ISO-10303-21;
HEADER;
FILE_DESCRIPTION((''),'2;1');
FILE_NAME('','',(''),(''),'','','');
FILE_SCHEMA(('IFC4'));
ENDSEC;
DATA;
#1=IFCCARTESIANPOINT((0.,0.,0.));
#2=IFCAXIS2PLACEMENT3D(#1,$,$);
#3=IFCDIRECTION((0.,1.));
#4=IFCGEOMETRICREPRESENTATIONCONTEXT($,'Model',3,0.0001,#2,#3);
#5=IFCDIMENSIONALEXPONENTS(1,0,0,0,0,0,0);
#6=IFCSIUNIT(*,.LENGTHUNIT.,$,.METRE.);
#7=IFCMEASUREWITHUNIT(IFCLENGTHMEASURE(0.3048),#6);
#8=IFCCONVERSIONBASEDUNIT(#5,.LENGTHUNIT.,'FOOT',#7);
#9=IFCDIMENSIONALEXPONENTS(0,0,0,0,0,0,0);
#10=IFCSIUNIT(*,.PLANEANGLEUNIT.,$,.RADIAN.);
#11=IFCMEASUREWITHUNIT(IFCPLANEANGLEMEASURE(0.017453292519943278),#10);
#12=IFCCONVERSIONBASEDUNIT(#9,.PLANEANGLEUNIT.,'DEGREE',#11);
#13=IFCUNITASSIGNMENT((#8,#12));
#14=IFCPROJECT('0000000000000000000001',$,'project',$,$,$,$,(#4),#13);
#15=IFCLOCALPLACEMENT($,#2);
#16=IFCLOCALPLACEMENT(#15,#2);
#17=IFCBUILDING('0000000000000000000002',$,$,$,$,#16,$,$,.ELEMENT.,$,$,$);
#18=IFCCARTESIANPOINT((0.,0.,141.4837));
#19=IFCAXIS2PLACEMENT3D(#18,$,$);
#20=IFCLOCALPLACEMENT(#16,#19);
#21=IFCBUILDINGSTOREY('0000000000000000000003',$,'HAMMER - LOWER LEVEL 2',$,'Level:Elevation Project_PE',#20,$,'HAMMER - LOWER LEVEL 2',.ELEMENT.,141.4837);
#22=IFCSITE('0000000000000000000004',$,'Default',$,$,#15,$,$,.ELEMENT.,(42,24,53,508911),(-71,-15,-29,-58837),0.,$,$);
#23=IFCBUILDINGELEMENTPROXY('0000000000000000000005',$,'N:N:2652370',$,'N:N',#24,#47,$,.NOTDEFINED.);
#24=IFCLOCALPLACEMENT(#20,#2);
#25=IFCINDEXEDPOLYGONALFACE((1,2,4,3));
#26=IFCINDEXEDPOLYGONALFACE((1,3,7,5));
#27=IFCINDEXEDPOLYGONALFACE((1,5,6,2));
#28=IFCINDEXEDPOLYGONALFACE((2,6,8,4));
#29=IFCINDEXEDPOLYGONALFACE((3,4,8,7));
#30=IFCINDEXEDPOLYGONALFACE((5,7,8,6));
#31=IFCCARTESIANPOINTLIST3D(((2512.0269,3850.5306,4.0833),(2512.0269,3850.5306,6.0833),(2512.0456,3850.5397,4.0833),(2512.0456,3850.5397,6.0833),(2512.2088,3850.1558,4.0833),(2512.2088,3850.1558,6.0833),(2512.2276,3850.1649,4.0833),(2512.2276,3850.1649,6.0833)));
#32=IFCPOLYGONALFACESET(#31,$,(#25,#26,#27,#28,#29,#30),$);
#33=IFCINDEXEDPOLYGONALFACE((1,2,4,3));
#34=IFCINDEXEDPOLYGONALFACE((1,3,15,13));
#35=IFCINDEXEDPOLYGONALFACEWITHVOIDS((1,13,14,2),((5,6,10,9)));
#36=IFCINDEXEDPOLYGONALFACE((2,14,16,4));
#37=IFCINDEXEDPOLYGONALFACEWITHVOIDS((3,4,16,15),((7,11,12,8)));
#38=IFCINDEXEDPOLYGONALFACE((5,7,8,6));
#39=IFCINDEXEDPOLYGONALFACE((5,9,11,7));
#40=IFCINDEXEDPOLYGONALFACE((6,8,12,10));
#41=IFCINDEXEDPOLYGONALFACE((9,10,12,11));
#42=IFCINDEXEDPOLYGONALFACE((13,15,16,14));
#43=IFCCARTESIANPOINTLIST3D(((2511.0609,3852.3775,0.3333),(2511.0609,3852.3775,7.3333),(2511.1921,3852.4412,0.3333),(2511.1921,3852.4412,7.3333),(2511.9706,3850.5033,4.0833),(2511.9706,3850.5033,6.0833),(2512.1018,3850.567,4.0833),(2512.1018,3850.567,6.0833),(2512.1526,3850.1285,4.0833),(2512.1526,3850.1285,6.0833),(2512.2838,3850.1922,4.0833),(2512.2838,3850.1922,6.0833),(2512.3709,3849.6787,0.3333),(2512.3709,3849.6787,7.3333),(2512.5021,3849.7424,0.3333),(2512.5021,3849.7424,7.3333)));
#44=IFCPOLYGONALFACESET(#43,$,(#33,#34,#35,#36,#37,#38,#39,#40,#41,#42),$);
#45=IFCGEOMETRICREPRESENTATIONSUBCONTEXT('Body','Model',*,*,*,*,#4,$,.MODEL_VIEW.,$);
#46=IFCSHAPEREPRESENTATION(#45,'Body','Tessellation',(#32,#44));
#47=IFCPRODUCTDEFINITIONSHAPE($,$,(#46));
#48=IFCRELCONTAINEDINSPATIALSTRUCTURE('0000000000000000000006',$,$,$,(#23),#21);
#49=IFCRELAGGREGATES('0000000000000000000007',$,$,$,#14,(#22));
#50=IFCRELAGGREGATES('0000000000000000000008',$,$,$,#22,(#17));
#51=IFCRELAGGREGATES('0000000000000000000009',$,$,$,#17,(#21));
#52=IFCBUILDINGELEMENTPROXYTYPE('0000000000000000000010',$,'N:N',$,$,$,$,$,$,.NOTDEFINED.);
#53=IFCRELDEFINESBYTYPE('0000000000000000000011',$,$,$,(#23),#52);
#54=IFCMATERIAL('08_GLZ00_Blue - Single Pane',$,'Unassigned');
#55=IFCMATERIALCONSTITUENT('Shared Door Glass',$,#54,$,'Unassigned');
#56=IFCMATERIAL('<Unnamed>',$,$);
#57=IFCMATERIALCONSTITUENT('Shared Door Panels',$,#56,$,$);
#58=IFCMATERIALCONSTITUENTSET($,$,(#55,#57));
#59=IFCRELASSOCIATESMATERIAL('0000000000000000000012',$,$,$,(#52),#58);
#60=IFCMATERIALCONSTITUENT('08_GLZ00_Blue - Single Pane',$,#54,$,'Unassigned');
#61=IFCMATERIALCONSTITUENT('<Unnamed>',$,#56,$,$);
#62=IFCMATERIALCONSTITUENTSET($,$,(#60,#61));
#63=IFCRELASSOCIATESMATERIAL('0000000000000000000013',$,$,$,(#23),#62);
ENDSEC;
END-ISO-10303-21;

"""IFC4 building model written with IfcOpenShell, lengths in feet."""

from ifc_helpers import new_model, entity, si_unit, converted_unit, direction, frame, origin, place, context, subcontext, project, spatial, indexed_curve, outline, extrude, source, transform, mapped, material, constituent, constituent_set, type_object, type_shapes, element, save


model = new_model("IFC4")

# Units and contexts
model_context = context("Model", 3, precision=0.0001, world=origin(), true_north=direction((0.0, 1.0)))
body_context = subcontext(model_context, "Body", "Model", "MODEL_VIEW")
ifc_project = project(units=[converted_unit("LENGTHUNIT", "FOOT", entity("IfcLengthMeasure", 0.3048), si_unit("LENGTHUNIT", "METRE"), dimensions=[1, 0, 0, 0, 0, 0, 0]), converted_unit("PLANEANGLEUNIT", "DEGREE", entity("IfcPlaneAngleMeasure", 0.017453292519943278), si_unit("PLANEANGLEUNIT", "RADIAN"), dimensions=[0, 0, 0, 0, 0, 0, 0])], contexts=[model_context])

# Site, building, storey
site_placement = place(None, origin())
site = spatial("IfcSite", under=ifc_project, at=site_placement, Name="Default", CompositionType="ELEMENT", RefLatitude=(42, 24, 53, 508911), RefLongitude=(-71, -15, -29, -58837), RefElevation=0.0)
building_placement = place(site_placement, origin())
building = spatial("IfcBuilding", under=site, at=building_placement, CompositionType="ELEMENT")
storey_placement = place(building_placement, frame((0.0, 0.0, 141.4837)))
storey = spatial("IfcBuildingStorey", under=building, at=storey_placement, Name="HAMMER - LOWER LEVEL 2", ObjectType="Level:Elevation Project_PE", LongName="HAMMER - LOWER LEVEL 2", CompositionType="ELEMENT", Elevation=141.4837)

# Shared definitions
ifc_material_1 = material(Name="<Unnamed>")

# Building element proxy
ifc_material_2 = material(Name="08_GLZ00_Blue - Single Pane", Category="Unassigned")
ifc_constituent_1 = constituent(ifc_material_2, Name="Shared Door Glass", Category="Unassigned")
ifc_constituent_2 = constituent(ifc_material_1, Name="Shared Door Panels")
ifc_constituent_set_1 = constituent_set(constituents=[ifc_constituent_1, ifc_constituent_2])
building_element_proxy_type_1 = type_object("IfcBuildingElementProxyType", Name="N:N", PredefinedType="NOTDEFINED", material=ifc_constituent_set_1)
shared_shape_1 = source(origin(), body_context, "Body", "SweptSolid", [
    extrude(outline(indexed_curve([(-0.0104, -0.2083), (0.0104, -0.2083), (0.0104, 0.2083), (-0.0104, 0.2083), (-0.0104, -0.2083)], self_intersect=False)), frame((-1.0775, 3.25, 3.75), z_axis=(0.0, 0.0, 1.0), x_axis=(0.0, 1.0, 0.0)), (0.0, 0.0, 1.0), 2.0),
    extrude(outline(indexed_curve([(-3.5, -1.5), (3.5, -1.5), (3.5, 1.5), (-3.5, 1.5), (-3.5, -1.5)], self_intersect=False), holes=[indexed_curve([(-2.25, 0.5833), (-2.25, 1.0), (-0.25, 1.0), (-0.25, 0.5833), (-2.25, 0.5833)], self_intersect=False)]), frame((-0.2859, 3.1771, 3.5), z_axis=(0.0, 1.0, 0.0), x_axis=(0.0, 0.0, -1.0)), (0.0, 0.0, 1.0), 0.1458),
])
type_shapes(building_element_proxy_type_1, [shared_shape_1])
ifc_constituent_3 = constituent(ifc_material_2, Name="08_GLZ00_Blue - Single Pane", Category="Unassigned")
ifc_constituent_4 = constituent(ifc_material_1, Name="<Unnamed>")
ifc_constituent_set_2 = constituent_set(constituents=[ifc_constituent_3, ifc_constituent_4])
proxy_1_placement = place(storey_placement, frame((2514.5804, 3852.7363, 0.3333), z_axis=(0.0, 0.0, 1.0), x_axis=(-0.436683, 0.899615, 0.0)))
element("IfcBuildingElementProxy", 1, at=proxy_1_placement, inside=storey, type_object=building_element_proxy_type_1, material=ifc_constituent_set_2, Name="N:N:2652370", ObjectType="N:N", PredefinedType="NOTDEFINED", context=body_context, shape_type="MappedRepresentation", body=[
    mapped(shared_shape_1, transform((0.0, 0.0, 0.0), scale=1.0)),
])

save(model, "model.ifc")
